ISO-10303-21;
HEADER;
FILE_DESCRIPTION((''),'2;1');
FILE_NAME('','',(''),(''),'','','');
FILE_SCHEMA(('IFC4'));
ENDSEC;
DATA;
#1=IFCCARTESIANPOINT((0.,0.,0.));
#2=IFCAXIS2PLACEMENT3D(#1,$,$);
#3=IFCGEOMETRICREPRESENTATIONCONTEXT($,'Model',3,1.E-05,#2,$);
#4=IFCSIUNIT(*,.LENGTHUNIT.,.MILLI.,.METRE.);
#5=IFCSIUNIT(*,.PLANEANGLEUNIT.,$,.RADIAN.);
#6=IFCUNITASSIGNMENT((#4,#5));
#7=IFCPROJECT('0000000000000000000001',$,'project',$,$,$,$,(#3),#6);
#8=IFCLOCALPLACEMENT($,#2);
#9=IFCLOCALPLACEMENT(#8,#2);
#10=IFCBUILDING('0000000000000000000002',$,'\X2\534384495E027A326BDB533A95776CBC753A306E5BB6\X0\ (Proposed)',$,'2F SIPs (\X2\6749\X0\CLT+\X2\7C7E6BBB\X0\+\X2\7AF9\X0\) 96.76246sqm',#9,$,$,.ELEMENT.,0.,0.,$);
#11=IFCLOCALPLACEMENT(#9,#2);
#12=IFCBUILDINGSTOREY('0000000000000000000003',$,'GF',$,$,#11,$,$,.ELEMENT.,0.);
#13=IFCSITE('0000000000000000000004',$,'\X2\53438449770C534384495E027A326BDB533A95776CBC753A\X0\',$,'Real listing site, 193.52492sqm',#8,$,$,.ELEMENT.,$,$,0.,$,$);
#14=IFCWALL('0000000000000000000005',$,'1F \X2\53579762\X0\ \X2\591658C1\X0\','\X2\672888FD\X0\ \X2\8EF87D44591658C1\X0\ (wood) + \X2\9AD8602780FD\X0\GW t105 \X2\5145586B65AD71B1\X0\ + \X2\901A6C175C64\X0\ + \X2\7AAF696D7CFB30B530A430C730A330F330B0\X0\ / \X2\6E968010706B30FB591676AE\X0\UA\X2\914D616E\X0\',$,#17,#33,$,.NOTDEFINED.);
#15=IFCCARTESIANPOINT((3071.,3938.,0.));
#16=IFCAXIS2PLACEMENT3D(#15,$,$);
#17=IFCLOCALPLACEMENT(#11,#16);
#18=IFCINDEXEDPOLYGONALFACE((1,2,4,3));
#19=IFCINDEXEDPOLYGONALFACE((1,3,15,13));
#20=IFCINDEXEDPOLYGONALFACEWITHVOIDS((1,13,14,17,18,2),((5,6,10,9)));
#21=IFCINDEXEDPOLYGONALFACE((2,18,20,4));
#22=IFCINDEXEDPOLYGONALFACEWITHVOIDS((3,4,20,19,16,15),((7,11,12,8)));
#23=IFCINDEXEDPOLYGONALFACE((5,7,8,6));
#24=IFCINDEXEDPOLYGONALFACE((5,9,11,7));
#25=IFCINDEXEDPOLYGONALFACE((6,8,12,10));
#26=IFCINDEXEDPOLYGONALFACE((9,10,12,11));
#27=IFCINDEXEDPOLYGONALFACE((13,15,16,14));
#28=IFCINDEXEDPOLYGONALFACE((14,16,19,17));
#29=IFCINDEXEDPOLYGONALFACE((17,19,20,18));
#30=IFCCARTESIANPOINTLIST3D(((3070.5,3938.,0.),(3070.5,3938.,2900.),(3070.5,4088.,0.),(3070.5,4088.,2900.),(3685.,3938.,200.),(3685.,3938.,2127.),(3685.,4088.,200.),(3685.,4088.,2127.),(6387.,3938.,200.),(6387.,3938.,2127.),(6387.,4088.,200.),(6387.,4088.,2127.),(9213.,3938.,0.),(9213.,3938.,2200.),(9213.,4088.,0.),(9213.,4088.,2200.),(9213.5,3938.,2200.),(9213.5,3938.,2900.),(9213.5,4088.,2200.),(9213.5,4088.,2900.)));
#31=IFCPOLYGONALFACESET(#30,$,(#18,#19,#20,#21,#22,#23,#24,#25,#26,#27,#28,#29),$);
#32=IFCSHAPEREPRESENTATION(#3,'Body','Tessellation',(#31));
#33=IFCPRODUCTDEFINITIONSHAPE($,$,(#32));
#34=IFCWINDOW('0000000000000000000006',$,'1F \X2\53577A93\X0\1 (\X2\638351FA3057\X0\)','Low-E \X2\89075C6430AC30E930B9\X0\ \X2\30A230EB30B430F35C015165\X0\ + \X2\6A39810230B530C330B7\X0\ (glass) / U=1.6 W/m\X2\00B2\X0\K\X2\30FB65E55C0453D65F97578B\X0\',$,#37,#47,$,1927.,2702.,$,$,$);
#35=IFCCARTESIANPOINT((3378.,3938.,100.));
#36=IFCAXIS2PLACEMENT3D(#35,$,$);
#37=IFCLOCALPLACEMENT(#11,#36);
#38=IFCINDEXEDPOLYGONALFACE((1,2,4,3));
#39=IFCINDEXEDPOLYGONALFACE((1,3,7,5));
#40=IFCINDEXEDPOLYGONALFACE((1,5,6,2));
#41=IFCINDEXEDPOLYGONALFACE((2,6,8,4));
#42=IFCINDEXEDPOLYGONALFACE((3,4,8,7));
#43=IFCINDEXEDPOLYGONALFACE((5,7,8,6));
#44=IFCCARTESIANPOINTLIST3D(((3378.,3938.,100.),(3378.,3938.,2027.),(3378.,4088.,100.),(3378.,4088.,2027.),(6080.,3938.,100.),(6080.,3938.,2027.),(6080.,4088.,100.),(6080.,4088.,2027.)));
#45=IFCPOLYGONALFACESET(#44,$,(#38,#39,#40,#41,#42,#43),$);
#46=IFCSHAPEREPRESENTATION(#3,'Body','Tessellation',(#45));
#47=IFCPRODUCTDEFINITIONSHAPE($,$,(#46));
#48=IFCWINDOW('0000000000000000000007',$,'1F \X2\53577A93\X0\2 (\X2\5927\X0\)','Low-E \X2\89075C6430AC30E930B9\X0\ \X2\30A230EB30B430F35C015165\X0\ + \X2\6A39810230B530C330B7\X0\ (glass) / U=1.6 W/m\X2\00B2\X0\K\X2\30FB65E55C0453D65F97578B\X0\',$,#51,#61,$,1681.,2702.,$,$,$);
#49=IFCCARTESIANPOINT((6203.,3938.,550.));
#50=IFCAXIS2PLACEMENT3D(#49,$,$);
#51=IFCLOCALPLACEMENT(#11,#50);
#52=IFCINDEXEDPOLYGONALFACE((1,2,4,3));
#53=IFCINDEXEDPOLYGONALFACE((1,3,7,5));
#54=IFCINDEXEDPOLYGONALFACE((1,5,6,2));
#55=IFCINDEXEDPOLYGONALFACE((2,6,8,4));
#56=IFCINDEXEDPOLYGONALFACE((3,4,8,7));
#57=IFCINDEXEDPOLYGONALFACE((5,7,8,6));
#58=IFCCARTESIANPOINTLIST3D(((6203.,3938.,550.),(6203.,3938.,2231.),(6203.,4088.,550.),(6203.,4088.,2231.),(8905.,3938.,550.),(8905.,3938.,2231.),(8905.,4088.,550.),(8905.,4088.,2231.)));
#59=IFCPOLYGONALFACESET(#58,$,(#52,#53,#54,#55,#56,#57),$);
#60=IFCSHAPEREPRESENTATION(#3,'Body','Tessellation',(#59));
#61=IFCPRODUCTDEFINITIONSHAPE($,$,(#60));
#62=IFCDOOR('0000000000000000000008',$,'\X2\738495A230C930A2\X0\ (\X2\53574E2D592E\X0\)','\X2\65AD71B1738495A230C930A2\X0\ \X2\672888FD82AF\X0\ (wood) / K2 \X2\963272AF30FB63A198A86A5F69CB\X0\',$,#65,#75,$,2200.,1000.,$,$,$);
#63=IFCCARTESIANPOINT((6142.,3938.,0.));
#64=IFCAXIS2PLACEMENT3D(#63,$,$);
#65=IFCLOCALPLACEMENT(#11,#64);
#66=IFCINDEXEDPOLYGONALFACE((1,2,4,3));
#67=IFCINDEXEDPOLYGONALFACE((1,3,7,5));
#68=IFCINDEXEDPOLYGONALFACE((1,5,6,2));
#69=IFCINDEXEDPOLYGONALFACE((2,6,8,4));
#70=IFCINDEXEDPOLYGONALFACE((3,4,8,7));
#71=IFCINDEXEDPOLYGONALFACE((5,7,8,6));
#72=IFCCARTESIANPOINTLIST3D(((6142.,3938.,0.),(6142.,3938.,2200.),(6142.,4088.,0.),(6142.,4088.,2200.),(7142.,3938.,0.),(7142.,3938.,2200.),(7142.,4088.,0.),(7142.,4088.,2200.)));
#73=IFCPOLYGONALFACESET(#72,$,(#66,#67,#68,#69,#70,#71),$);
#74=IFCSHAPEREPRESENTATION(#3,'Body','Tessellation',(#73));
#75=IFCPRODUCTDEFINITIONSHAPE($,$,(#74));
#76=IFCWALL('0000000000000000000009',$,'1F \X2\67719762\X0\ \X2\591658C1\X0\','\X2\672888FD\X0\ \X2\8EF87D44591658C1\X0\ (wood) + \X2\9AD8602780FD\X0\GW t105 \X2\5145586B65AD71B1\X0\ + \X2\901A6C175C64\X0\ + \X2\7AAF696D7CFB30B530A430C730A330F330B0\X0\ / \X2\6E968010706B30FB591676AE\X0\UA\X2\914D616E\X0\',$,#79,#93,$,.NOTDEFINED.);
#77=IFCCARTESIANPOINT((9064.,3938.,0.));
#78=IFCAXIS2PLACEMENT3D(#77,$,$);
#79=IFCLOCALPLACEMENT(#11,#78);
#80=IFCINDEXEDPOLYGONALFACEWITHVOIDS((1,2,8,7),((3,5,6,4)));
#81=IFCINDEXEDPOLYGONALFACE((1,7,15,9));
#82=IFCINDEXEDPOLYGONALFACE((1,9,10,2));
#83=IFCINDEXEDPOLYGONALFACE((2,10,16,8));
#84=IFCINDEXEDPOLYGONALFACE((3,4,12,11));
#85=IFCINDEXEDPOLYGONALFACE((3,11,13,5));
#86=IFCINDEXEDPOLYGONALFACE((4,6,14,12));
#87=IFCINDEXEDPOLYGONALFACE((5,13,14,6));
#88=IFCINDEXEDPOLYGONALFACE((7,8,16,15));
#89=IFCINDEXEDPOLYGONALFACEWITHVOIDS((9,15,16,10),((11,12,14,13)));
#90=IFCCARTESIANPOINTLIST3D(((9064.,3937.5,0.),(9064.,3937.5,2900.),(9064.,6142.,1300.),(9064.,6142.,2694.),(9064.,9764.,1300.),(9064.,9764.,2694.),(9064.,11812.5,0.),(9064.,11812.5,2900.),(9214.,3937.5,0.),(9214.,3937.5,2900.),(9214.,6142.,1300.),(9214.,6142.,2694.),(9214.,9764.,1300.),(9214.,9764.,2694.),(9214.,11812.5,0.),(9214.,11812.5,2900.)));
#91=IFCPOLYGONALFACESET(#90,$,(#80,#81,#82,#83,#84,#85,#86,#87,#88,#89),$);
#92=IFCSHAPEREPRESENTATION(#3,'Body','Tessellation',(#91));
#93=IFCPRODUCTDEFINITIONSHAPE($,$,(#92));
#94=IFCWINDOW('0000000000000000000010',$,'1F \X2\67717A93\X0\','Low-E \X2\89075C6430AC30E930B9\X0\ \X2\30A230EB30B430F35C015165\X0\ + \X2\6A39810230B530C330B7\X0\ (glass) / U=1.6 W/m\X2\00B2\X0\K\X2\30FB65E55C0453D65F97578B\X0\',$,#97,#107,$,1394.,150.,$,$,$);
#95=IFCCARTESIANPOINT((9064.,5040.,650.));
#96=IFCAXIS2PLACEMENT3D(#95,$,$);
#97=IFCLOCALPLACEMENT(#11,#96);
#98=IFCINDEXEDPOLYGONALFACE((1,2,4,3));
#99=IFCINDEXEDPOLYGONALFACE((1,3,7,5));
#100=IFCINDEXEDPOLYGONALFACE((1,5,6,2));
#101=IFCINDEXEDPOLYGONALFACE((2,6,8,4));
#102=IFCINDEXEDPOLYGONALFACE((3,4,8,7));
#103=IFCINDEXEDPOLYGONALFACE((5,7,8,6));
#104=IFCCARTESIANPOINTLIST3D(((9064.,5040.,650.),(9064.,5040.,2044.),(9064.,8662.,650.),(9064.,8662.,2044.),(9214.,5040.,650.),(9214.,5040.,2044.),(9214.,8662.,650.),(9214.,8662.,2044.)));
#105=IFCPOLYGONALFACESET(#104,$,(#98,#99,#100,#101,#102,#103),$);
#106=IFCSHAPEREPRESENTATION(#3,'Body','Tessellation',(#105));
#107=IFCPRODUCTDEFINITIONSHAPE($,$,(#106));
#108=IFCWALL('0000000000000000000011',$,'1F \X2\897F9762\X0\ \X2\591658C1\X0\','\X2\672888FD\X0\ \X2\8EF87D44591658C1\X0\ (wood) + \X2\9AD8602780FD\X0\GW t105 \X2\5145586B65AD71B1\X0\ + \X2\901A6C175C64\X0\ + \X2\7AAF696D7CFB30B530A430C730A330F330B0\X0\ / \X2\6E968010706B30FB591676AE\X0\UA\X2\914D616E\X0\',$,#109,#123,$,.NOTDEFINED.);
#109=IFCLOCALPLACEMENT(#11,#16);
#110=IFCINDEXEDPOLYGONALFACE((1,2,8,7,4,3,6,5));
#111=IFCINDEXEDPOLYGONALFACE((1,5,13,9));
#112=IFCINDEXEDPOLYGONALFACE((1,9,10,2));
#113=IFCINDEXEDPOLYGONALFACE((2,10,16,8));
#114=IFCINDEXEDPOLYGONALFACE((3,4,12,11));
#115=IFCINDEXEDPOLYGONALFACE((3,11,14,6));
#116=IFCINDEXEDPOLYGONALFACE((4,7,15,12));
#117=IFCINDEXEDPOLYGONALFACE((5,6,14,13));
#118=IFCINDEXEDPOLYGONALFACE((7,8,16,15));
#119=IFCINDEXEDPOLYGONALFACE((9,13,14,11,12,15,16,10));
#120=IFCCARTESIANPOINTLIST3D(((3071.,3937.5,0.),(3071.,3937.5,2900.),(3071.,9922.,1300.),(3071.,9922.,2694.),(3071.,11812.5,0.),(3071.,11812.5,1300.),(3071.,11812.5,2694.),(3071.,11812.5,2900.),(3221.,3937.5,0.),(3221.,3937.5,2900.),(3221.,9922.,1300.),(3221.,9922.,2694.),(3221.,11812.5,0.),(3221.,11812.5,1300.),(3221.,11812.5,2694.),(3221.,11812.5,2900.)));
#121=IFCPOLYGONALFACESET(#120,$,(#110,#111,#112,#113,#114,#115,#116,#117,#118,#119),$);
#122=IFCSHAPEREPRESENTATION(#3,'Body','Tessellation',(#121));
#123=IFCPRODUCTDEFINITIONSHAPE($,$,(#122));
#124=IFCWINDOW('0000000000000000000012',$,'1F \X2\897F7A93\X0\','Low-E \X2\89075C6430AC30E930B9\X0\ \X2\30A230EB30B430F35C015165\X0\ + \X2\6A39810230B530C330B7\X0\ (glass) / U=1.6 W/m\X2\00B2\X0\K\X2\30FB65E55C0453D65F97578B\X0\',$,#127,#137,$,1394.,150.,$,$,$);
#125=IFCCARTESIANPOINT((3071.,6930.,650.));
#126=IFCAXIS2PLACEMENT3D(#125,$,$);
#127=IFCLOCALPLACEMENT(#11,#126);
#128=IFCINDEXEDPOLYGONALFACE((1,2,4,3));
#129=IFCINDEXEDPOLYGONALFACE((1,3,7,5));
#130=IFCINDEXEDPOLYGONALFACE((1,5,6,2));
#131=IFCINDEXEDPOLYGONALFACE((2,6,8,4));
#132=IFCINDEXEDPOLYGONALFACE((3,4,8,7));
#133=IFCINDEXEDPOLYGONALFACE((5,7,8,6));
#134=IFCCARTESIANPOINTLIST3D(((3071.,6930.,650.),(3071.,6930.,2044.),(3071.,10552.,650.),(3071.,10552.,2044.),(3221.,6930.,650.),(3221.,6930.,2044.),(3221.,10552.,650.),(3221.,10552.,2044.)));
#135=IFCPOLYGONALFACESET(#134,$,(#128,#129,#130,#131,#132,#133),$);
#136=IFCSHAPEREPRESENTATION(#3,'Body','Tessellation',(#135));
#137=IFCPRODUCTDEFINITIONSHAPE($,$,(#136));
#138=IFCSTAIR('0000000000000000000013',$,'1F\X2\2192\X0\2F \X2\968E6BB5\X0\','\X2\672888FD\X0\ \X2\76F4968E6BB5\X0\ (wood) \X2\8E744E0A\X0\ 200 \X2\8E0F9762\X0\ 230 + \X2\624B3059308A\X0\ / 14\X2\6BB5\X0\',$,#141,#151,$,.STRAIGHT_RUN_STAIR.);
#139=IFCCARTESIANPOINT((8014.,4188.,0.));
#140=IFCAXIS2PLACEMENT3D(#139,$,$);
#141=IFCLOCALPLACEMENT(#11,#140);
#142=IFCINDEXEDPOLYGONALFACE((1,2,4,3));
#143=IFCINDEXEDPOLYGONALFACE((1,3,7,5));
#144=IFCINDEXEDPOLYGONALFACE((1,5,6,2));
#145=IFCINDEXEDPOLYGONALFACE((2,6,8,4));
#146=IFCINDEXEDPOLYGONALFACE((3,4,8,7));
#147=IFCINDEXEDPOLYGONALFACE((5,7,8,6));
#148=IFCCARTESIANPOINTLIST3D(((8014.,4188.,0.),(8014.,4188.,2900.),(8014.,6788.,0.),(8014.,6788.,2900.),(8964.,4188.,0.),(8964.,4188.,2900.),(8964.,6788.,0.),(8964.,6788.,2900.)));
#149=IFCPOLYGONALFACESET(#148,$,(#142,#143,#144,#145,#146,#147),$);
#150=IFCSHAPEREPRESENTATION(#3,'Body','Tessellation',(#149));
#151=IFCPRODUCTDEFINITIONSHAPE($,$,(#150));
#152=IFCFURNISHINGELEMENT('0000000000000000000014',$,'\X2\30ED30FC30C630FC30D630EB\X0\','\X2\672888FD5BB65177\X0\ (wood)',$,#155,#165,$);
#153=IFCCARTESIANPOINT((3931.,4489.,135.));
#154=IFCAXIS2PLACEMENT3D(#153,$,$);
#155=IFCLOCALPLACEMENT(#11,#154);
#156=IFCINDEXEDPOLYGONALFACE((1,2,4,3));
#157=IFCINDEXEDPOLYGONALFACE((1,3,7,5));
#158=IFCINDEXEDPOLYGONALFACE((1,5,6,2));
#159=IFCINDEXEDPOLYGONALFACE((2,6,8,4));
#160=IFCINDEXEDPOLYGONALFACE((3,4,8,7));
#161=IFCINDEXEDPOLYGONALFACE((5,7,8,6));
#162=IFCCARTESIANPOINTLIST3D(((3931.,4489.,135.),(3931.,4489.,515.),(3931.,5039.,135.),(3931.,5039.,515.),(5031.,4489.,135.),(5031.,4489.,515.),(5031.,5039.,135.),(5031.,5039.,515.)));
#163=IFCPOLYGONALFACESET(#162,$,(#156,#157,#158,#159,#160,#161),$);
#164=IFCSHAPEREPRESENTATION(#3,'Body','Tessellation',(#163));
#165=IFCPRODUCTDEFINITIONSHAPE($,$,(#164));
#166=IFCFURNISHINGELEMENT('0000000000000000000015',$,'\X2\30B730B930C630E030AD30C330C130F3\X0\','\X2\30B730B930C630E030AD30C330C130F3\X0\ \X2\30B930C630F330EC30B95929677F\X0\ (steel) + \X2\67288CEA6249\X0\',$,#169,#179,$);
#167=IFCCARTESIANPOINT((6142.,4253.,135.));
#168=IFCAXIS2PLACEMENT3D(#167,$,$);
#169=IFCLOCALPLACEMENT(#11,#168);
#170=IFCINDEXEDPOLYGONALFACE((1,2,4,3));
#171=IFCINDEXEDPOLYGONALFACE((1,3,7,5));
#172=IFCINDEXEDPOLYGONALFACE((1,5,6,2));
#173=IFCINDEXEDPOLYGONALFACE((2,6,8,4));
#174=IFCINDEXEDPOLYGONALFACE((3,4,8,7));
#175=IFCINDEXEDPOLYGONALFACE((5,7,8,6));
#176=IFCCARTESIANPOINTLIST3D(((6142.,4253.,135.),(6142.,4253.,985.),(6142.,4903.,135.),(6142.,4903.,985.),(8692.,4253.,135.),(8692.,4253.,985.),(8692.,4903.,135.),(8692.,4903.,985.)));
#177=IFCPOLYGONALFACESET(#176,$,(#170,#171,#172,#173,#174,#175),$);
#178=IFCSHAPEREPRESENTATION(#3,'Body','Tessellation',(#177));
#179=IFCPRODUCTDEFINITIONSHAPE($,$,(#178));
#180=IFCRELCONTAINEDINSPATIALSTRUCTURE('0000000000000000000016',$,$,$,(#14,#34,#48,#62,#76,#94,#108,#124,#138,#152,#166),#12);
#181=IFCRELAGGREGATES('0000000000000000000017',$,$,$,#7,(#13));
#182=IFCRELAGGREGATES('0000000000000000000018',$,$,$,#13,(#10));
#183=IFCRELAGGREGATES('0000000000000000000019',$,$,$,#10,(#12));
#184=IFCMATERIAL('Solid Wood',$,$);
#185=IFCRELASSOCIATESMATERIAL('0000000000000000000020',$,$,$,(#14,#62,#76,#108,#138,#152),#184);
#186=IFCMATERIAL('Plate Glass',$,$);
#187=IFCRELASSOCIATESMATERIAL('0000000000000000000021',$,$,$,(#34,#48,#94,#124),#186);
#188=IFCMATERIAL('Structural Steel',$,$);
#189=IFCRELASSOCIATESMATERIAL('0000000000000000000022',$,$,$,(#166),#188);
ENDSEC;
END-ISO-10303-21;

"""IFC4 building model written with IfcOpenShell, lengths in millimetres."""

from ifc_helpers import new_model, si_unit, frame, frame_2d, origin, place, context, project, spatial, rectangle, extrude, material, element, fill, save


model = new_model("IFC4")

# Units and contexts
model_context = context("Model", 3, precision=1e-05, world=origin())
ifc_project = project(units=[si_unit("LENGTHUNIT", "METRE", prefix="MILLI"), si_unit("PLANEANGLEUNIT", "RADIAN")], contexts=[model_context])

# Site, building, storey
site_placement = place(None, origin())
site = spatial("IfcSite", under=ifc_project, at=site_placement, Name="千葉県千葉市稲毛区長沼町", ObjectType="Real listing site, 193.52492sqm", CompositionType="ELEMENT", RefElevation=0.0)
building_placement = place(site_placement, origin())
building = spatial("IfcBuilding", under=site, at=building_placement, Name="千葉市稲毛区長沼町の家 (Proposed)", ObjectType="2F SIPs (杉CLT+籾殻+竹) 96.76246sqm", CompositionType="ELEMENT", ElevationOfRefHeight=0.0, ElevationOfTerrain=0.0)
storey_placement = place(building_placement, origin())
storey = spatial("IfcBuildingStorey", under=building, at=storey_placement, Name="GF", CompositionType="ELEMENT", Elevation=0.0)

# Shared definitions
ifc_material_1 = material(Name="Solid Wood")

# Wall, openings, windows, door
wall_1_placement = place(storey_placement, frame((3071.0, 3938.0, 0.0)))
wall_1 = element("IfcWall", 1, at=wall_1_placement, inside=storey, material=ifc_material_1, Name="1F 南面 外壁", Description="木製 軸組外壁 (wood) + 高性能GW t105 充填断熱 + 通気層 + 窯業系サイディング / 準耐火・外皮UA配慮", PredefinedType="NOTDEFINED", context=model_context, shape_type="SweptSolid", body=[
    extrude(rectangle(XDim=6143.0, YDim=150.0, at=frame_2d((3071.0, 75.0))), frame((3071.0, 3938.0, 0.0)), (0.0, 0.0, 1.0), 2900.0),
])
opening_1_placement = place(storey_placement, frame((3378.0, 3938.0, 100.0)))
opening_1 = element("IfcOpeningElement", 2, at=opening_1_placement, cuts=wall_1, PredefinedType="NOTDEFINED", context=model_context, shape_type="SweptSolid", body=[
    extrude(rectangle(XDim=2702.0, YDim=150.0, at=frame_2d((1351.0, 75.0))), frame((3378.0, 3938.0, 100.0)), (0.0, 0.0, 1.0), 1927.0),
])
opening_2_placement = place(storey_placement, frame((6203.0, 3938.0, 550.0)))
opening_2 = element("IfcOpeningElement", 3, at=opening_2_placement, cuts=wall_1, PredefinedType="NOTDEFINED", context=model_context, shape_type="SweptSolid", body=[
    extrude(rectangle(XDim=2702.0, YDim=150.0, at=frame_2d((1351.0, 75.0))), frame((6203.0, 3938.0, 550.0)), (0.0, 0.0, 1.0), 1681.0),
])
opening_3_placement = place(storey_placement, frame((6142.0, 3938.0, 0.0)))
opening_3 = element("IfcOpeningElement", 4, at=opening_3_placement, cuts=wall_1, PredefinedType="NOTDEFINED", context=model_context, shape_type="SweptSolid", body=[
    extrude(rectangle(XDim=1000.0, YDim=150.0, at=frame_2d((500.0, 75.0))), frame((6142.0, 3938.0, 0.0)), (0.0, 0.0, 1.0), 2200.0),
])
ifc_material_2 = material(Name="Plate Glass")
window_1_placement = place(storey_placement, frame((3378.0, 3938.0, 100.0)))
window_1 = element("IfcWindow", 5, at=window_1_placement, inside=storey, material=ifc_material_2, Name="1F 南窓1 (掃出し)", Description="Low-E 複層ガラス アルゴン封入 + 樹脂サッシ (glass) / U=1.6 W/m²K・日射取得型", OverallHeight=1927.0, OverallWidth=2702.0, context=model_context, shape_type="SweptSolid", body=[
    extrude(rectangle(XDim=2702.0, YDim=150.0, at=frame_2d((1351.0, 75.0))), frame((3378.0, 3938.0, 100.0)), (0.0, 0.0, 1.0), 1927.0),
])
fill(opening_1, window_1)
window_2_placement = place(storey_placement, frame((6203.0, 3938.0, 550.0)))
window_2 = element("IfcWindow", 6, at=window_2_placement, inside=storey, material=ifc_material_2, Name="1F 南窓2 (大)", Description="Low-E 複層ガラス アルゴン封入 + 樹脂サッシ (glass) / U=1.6 W/m²K・日射取得型", OverallHeight=1681.0, OverallWidth=2702.0, context=model_context, shape_type="SweptSolid", body=[
    extrude(rectangle(XDim=2702.0, YDim=150.0, at=frame_2d((1351.0, 75.0))), frame((6203.0, 3938.0, 550.0)), (0.0, 0.0, 1.0), 1681.0),
])
fill(opening_2, window_2)
door_placement = place(storey_placement, frame((6142.0, 3938.0, 0.0)))
door = element("IfcDoor", 7, at=door_placement, inside=storey, material=ifc_material_1, Name="玄関ドア (南中央)", Description="断熱玄関ドア 木製芯 (wood) / K2 防犯・採風機構", OverallHeight=2200.0, OverallWidth=1000.0, context=model_context, shape_type="SweptSolid", body=[
    extrude(rectangle(XDim=1000.0, YDim=150.0, at=frame_2d((500.0, 75.0))), frame((6142.0, 3938.0, 0.0)), (0.0, 0.0, 1.0), 2200.0),
])
fill(opening_3, door)

# Walls, openings, windows
wall_2_placement = place(storey_placement, frame((9064.0, 3938.0, 0.0)))
wall_2 = element("IfcWall", 8, at=wall_2_placement, inside=storey, material=ifc_material_1, Name="1F 東面 外壁", Description="木製 軸組外壁 (wood) + 高性能GW t105 充填断熱 + 通気層 + 窯業系サイディング / 準耐火・外皮UA配慮", PredefinedType="NOTDEFINED", context=model_context, shape_type="SweptSolid", body=[
    extrude(rectangle(XDim=150.0, YDim=7875.0, at=frame_2d((75.0, 3937.0))), frame((9064.0, 3938.0, 0.0)), (0.0, 0.0, 1.0), 2900.0),
])
opening_4_placement = place(storey_placement, frame((9064.0, 5040.0, 650.0)))
opening_4 = element("IfcOpeningElement", 9, at=opening_4_placement, cuts=wall_2, PredefinedType="NOTDEFINED", context=model_context, shape_type="SweptSolid", body=[
    extrude(rectangle(XDim=150.0, YDim=3622.0, at=frame_2d((75.0, 1811.0))), frame((9064.0, 5040.0, 650.0)), (0.0, 0.0, 1.0), 1394.0),
])
window_3_placement = place(storey_placement, frame((9064.0, 5040.0, 650.0)))
window_3 = element("IfcWindow", 10, at=window_3_placement, inside=storey, material=ifc_material_2, Name="1F 東窓", Description="Low-E 複層ガラス アルゴン封入 + 樹脂サッシ (glass) / U=1.6 W/m²K・日射取得型", OverallHeight=1394.0, OverallWidth=150.0, context=model_context, shape_type="SweptSolid", body=[
    extrude(rectangle(XDim=150.0, YDim=3622.0, at=frame_2d((75.0, 1811.0))), frame((9064.0, 5040.0, 650.0)), (0.0, 0.0, 1.0), 1394.0),
])
fill(opening_4, window_3)
wall_3_placement = place(storey_placement, frame((3071.0, 3938.0, 0.0)))
wall_3 = element("IfcWall", 11, at=wall_3_placement, inside=storey, material=ifc_material_1, Name="1F 西面 外壁", Description="木製 軸組外壁 (wood) + 高性能GW t105 充填断熱 + 通気層 + 窯業系サイディング / 準耐火・外皮UA配慮", PredefinedType="NOTDEFINED", context=model_context, shape_type="SweptSolid", body=[
    extrude(rectangle(XDim=150.0, YDim=7875.0, at=frame_2d((75.0, 3937.0))), frame((3071.0, 3938.0, 0.0)), (0.0, 0.0, 1.0), 2900.0),
])
opening_5_placement = place(storey_placement, frame((3071.0, 6930.0, 650.0)))
opening_5 = element("IfcOpeningElement", 12, at=opening_5_placement, cuts=wall_3, PredefinedType="NOTDEFINED", context=model_context, shape_type="SweptSolid", body=[
    extrude(rectangle(XDim=150.0, YDim=3622.0, at=frame_2d((75.0, 1811.0))), frame((3071.0, 6930.0, 650.0)), (0.0, 0.0, 1.0), 1394.0),
])
window_4_placement = place(storey_placement, frame((3071.0, 6930.0, 650.0)))
window_4 = element("IfcWindow", 13, at=window_4_placement, inside=storey, material=ifc_material_2, Name="1F 西窓", Description="Low-E 複層ガラス アルゴン封入 + 樹脂サッシ (glass) / U=1.6 W/m²K・日射取得型", OverallHeight=1394.0, OverallWidth=150.0, context=model_context, shape_type="SweptSolid", body=[
    extrude(rectangle(XDim=150.0, YDim=3622.0, at=frame_2d((75.0, 1811.0))), frame((3071.0, 6930.0, 650.0)), (0.0, 0.0, 1.0), 1394.0),
])
fill(opening_5, window_4)

# Stair
stair_placement = place(storey_placement, frame((8014.0, 4188.0, 0.0)))
element("IfcStair", 14, at=stair_placement, inside=storey, material=ifc_material_1, Name="1F→2F 階段", Description="木製 直階段 (wood) 蹴上 200 踏面 230 + 手すり / 14段", PredefinedType="STRAIGHT_RUN_STAIR", context=model_context, shape_type="SweptSolid", body=[
    extrude(rectangle(XDim=950.0, YDim=2600.0, at=frame_2d((475.0, 1300.0))), frame((8014.0, 4188.0, 0.0)), (0.0, 0.0, 1.0), 2900.0),
])

# Furnishing elements
furnishing_1_placement = place(storey_placement, frame((3931.0, 4489.0, 135.0)))
element("IfcFurnishingElement", 15, at=furnishing_1_placement, inside=storey, material=ifc_material_1, Name="ローテーブル", Description="木製家具 (wood)", context=model_context, shape_type="SweptSolid", body=[
    extrude(rectangle(XDim=1100.0, YDim=550.0, at=frame_2d((550.0, 275.0))), frame((3931.0, 4489.0, 135.0)), (0.0, 0.0, 1.0), 380.0),
])
ifc_material_3 = material(Name="Structural Steel")
furnishing_2_placement = place(storey_placement, frame((6142.0, 4253.0, 135.0)))
element("IfcFurnishingElement", 16, at=furnishing_2_placement, inside=storey, material=ifc_material_3, Name="システムキッチン", Description="システムキッチン ステンレス天板 (steel) + 木質扉", context=model_context, shape_type="SweptSolid", body=[
    extrude(rectangle(XDim=2550.0, YDim=650.0, at=frame_2d((1275.0, 325.0))), frame((6142.0, 4253.0, 135.0)), (0.0, 0.0, 1.0), 850.0),
])

save(model, "model.ifc")
